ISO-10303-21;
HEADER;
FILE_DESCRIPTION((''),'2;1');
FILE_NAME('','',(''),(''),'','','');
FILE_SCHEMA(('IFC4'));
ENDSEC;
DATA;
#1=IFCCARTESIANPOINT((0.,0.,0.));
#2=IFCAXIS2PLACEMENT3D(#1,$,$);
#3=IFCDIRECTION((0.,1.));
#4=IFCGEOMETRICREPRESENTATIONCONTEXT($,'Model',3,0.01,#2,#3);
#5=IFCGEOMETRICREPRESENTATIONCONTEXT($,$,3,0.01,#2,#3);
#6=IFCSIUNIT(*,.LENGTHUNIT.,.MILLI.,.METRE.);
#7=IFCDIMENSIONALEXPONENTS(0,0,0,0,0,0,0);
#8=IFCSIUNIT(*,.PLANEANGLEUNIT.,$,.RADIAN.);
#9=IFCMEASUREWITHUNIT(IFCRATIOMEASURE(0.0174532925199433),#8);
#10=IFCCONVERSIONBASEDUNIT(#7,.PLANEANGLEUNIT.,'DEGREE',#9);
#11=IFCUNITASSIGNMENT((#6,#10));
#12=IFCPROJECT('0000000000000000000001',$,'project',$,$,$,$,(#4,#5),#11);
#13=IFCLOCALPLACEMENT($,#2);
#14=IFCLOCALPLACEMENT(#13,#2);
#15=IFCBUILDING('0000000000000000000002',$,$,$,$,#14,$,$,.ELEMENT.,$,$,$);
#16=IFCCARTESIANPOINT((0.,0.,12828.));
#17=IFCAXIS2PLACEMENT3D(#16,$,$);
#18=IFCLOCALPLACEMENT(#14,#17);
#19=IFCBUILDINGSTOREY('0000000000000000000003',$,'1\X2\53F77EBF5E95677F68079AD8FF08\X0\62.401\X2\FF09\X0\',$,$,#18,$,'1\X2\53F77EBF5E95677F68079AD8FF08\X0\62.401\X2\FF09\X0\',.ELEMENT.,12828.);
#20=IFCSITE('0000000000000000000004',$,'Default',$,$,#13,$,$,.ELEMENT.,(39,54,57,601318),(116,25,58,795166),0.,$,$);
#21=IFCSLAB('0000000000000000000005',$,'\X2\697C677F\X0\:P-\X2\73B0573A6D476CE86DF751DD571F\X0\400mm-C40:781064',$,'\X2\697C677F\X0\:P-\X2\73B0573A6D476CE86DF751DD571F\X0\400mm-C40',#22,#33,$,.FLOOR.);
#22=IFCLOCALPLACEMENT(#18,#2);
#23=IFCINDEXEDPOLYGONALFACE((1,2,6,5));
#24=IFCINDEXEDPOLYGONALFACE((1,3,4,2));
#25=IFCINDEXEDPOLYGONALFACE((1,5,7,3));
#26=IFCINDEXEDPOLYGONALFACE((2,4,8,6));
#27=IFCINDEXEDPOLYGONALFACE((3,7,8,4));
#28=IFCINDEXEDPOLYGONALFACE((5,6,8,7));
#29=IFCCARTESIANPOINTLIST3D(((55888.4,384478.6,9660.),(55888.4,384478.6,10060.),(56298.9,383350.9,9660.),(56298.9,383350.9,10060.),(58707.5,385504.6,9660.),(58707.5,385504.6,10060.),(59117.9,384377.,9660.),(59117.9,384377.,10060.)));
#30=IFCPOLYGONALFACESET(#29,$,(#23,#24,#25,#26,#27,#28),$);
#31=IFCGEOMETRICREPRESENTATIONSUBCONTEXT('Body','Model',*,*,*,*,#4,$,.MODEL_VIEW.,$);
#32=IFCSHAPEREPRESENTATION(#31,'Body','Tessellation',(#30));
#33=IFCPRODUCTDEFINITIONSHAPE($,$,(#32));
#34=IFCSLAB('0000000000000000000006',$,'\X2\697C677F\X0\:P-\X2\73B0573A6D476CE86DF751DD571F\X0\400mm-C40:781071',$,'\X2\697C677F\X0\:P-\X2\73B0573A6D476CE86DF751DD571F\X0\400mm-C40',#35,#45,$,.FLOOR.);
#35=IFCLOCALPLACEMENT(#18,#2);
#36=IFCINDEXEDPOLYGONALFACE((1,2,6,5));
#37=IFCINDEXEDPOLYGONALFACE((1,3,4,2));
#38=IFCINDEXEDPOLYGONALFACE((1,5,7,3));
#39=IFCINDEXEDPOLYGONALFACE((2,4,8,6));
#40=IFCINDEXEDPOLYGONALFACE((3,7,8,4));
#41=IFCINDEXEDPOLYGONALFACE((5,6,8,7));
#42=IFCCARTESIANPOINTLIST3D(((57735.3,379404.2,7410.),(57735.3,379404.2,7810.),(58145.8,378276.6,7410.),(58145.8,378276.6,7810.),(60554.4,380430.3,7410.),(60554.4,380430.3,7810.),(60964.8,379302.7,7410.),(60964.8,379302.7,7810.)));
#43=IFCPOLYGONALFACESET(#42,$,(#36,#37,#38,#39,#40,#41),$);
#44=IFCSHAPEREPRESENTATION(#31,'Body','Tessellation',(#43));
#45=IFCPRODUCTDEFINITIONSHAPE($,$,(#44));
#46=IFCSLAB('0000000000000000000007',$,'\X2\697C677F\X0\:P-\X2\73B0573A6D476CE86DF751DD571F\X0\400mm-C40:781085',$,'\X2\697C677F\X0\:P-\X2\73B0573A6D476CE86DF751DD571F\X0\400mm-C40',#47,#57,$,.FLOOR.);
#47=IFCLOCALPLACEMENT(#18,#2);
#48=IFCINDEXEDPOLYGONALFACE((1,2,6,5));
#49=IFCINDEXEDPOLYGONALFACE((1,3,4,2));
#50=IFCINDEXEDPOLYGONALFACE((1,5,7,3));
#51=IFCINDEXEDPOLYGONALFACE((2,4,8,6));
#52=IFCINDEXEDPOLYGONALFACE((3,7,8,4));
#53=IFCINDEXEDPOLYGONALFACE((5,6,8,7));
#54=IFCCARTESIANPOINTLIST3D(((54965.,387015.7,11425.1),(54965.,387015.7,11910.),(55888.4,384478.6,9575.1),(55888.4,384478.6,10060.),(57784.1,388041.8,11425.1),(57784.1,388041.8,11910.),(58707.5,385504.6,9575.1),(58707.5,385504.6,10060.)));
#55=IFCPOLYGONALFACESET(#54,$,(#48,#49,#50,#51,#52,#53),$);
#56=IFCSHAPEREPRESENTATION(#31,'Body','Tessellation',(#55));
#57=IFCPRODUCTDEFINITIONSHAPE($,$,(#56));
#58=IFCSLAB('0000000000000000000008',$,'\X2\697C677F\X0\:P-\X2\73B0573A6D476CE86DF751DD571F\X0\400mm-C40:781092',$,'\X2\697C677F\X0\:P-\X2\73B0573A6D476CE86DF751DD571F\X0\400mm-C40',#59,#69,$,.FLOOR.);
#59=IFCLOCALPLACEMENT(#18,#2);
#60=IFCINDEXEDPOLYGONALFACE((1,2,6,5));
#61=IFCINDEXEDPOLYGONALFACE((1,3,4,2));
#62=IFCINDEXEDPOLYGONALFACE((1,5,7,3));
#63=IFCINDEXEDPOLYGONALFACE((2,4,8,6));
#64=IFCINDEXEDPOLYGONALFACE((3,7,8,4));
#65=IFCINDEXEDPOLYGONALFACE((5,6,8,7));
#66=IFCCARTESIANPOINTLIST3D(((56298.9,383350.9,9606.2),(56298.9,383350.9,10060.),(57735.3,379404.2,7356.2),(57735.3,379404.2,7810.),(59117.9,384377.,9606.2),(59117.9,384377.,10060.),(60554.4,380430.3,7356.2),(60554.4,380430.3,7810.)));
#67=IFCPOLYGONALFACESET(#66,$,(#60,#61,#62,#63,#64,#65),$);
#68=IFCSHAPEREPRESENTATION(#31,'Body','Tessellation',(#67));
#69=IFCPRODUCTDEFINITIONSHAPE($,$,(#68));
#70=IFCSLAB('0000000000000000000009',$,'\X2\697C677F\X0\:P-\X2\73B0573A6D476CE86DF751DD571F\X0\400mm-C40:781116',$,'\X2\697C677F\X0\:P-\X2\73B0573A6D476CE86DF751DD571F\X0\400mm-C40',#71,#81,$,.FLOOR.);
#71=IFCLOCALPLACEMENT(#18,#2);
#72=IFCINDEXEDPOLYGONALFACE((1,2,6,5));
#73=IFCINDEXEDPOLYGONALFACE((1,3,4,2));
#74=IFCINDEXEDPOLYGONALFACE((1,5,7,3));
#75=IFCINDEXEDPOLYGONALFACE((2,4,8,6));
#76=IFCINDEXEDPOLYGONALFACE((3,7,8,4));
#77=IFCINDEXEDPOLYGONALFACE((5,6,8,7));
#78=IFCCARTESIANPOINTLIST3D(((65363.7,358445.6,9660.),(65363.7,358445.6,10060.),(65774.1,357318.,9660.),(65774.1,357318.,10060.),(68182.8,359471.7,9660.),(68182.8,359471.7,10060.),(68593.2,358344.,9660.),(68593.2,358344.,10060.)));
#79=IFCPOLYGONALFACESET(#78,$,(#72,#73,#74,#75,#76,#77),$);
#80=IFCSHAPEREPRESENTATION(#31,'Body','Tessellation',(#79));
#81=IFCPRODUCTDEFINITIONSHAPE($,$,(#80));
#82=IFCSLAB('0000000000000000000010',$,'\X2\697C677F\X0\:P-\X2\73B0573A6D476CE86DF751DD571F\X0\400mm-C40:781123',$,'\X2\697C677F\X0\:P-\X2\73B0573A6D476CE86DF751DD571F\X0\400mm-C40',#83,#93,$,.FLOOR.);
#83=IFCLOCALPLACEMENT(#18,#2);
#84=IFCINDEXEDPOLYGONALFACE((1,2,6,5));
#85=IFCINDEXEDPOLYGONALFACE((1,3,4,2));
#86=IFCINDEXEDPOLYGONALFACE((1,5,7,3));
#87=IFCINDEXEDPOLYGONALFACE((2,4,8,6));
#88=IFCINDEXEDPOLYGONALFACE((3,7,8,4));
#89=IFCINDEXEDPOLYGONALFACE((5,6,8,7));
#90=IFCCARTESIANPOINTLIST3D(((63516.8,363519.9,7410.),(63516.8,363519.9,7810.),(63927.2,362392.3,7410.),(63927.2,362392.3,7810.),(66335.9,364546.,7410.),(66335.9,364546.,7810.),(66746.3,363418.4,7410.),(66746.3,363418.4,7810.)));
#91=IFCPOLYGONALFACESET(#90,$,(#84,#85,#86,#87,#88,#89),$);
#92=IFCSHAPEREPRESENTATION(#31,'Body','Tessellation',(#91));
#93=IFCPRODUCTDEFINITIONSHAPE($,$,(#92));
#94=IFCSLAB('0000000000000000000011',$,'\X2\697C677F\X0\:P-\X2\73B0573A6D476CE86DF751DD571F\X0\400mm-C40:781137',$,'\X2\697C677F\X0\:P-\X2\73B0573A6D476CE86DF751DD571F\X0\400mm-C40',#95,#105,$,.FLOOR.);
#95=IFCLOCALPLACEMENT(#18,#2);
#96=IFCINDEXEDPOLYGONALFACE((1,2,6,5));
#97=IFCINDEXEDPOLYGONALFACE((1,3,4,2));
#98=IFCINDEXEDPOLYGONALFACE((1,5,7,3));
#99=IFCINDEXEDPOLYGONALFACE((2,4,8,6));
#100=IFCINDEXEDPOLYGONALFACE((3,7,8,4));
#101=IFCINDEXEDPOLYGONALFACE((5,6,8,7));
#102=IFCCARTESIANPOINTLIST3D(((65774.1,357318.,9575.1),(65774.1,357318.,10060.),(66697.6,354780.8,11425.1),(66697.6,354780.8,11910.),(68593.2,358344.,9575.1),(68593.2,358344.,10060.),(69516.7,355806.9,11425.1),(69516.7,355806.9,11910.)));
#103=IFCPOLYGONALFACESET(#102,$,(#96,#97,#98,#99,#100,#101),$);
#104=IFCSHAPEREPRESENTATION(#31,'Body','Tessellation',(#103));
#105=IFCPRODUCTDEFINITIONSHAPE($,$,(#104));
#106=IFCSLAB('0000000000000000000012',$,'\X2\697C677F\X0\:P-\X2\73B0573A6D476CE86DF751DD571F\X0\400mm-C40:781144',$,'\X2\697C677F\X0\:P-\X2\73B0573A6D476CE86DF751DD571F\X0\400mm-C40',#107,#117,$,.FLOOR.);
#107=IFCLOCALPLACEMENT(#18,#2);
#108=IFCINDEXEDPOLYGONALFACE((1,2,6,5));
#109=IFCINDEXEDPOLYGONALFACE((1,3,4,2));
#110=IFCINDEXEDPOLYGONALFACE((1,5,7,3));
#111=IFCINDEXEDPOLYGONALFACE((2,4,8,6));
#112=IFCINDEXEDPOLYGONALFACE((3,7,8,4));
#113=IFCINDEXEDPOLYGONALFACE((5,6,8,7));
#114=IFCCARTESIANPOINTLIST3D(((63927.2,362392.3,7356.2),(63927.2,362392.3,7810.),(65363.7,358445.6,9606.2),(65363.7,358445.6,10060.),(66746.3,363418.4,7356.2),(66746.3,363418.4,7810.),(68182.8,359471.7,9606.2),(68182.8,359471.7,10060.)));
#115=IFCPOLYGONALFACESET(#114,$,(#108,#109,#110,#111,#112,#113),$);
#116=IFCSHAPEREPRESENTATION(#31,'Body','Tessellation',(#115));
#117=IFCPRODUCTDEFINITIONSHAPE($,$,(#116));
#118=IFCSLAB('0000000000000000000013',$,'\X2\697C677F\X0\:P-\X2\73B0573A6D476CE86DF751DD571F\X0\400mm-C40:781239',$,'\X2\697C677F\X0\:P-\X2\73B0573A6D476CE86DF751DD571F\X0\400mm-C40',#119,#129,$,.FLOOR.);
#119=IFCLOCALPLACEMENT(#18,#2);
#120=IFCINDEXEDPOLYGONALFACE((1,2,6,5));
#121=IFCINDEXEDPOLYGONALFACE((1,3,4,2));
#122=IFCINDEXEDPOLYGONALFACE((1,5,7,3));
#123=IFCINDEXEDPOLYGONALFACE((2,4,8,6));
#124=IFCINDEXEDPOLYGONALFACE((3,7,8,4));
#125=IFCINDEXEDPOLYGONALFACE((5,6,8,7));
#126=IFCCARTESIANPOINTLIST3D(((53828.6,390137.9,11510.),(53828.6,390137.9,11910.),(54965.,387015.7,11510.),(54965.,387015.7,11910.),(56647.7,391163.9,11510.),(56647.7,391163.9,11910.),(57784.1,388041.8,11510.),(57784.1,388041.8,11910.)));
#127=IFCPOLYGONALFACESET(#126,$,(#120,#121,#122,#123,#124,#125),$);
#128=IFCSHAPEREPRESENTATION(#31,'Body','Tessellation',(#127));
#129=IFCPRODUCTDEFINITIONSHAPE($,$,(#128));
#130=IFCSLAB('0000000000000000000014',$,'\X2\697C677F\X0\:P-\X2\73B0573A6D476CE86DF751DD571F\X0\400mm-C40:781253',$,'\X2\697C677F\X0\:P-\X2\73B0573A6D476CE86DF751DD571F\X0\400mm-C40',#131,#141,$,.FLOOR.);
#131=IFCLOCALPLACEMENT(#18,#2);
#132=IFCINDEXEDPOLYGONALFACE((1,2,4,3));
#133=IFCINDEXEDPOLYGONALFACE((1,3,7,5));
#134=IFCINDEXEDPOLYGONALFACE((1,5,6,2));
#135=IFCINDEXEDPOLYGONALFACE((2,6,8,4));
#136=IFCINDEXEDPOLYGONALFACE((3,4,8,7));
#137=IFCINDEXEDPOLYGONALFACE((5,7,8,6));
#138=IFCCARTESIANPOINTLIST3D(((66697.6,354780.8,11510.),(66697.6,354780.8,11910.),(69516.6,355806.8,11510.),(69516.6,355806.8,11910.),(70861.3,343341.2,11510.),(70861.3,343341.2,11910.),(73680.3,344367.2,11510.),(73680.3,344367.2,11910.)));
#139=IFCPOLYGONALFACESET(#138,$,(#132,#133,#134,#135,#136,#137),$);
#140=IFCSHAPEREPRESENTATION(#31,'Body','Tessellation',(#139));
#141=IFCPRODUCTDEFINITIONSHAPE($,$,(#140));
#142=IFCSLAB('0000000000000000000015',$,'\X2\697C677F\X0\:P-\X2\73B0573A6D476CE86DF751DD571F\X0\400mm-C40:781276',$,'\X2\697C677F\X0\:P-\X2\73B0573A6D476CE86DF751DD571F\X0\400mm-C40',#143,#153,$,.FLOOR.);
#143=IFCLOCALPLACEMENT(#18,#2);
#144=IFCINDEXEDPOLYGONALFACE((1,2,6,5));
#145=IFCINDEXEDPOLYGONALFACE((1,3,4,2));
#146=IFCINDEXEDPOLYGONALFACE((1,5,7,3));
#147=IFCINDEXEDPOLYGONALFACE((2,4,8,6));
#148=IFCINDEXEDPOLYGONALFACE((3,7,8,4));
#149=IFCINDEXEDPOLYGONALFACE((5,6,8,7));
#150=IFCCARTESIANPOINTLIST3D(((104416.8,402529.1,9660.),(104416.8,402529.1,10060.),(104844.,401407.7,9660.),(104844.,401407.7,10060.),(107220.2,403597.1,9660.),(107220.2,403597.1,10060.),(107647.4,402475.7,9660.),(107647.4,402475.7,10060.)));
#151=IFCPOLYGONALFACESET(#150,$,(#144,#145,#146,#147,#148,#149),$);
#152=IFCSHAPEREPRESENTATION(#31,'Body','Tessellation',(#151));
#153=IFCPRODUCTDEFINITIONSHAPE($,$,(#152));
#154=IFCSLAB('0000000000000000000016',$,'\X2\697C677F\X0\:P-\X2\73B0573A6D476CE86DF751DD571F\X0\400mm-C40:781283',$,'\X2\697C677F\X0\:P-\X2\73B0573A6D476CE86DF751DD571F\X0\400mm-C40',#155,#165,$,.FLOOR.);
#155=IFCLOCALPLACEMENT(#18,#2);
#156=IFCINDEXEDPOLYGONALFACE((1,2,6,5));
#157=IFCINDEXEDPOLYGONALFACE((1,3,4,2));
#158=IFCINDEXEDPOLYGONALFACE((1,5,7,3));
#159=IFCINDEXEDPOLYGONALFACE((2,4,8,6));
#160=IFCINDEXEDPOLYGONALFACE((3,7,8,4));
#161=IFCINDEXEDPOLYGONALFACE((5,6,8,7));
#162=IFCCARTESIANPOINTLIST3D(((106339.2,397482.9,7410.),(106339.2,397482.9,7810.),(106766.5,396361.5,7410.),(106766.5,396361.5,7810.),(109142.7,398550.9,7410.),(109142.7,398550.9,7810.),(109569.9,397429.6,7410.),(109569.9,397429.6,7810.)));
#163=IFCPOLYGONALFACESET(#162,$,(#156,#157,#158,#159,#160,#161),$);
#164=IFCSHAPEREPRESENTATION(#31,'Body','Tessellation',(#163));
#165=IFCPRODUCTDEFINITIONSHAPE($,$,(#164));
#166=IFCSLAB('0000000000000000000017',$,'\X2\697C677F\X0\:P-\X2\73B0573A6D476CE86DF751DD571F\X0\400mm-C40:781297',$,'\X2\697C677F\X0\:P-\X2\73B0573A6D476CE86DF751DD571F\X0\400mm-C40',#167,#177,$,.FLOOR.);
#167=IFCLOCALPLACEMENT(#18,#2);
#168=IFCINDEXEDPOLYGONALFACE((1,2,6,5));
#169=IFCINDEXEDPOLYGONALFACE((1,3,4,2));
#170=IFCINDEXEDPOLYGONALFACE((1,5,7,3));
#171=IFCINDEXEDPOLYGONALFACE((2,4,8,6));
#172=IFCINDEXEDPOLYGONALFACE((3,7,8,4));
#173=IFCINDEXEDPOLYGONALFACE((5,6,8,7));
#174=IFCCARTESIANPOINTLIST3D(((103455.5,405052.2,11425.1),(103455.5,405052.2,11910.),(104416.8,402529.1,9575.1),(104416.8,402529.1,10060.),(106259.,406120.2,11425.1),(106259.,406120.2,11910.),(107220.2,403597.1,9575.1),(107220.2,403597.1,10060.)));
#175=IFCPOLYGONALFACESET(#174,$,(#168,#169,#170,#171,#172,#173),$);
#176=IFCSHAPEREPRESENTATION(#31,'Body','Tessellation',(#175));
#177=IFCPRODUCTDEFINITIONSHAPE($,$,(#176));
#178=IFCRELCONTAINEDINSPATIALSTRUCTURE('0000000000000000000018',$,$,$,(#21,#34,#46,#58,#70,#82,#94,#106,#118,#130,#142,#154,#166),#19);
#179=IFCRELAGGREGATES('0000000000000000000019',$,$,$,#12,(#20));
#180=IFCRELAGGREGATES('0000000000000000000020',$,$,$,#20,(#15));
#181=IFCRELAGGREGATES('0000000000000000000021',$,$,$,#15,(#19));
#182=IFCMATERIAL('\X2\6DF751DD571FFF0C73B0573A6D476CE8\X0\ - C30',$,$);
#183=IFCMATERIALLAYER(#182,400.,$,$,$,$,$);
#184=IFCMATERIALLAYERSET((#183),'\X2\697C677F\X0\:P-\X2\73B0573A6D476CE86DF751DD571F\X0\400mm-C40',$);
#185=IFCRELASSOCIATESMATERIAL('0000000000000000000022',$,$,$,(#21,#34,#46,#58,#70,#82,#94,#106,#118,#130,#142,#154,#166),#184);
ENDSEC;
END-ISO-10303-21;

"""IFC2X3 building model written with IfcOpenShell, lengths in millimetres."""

from ifc_helpers import new_model, entity, si_unit, converted_unit, direction, frame, frame_2d, origin, place, context, subcontext, project, spatial, polyline, rectangle, outline, extrude, clip, halfspace, material, layer, layer_set, layer_usage, element, save


model = new_model("IFC2X3")

# Units and contexts
model_context = context("Model", 3, precision=0.01, world=origin(), true_north=direction((0.0, 1.0)))
context_of_model = context(None, 3, precision=0.01, world=origin(), true_north=direction((0.0, 1.0)))
body_context = subcontext(model_context, "Body", "Model", "MODEL_VIEW")
ifc_project = project(units=[si_unit("LENGTHUNIT", "METRE", prefix="MILLI"), converted_unit("PLANEANGLEUNIT", "DEGREE", entity("IfcRatioMeasure", 0.0174532925199433), si_unit("PLANEANGLEUNIT", "RADIAN"), dimensions=[0, 0, 0, 0, 0, 0, 0])], contexts=[model_context, context_of_model])

# Site, building, storey
site_placement = place(None, origin())
site = spatial("IfcSite", under=ifc_project, at=site_placement, Name="Default", CompositionType="ELEMENT", RefLatitude=(39, 54, 57, 601318), RefLongitude=(116, 25, 58, 795166), RefElevation=0.0)
building_placement = place(site_placement, origin())
building = spatial("IfcBuilding", under=site, at=building_placement, CompositionType="ELEMENT")
storey_placement = place(building_placement, frame((0.0, 0.0, 12828.0)))
storey = spatial("IfcBuildingStorey", under=building, at=storey_placement, Name="1号线底板标高（62.401）", LongName="1号线底板标高（62.401）", CompositionType="ELEMENT", Elevation=12828.0)

# Slabs
ifc_material = material(Name="混凝土，现场浇注 - C30")
ifc_layer = layer(ifc_material, 400.0)
ifc_layer_set = layer_set([ifc_layer], Name="楼板:P-现场浇注混凝土400mm-C40")
ifc_layer_usage_1 = layer_usage(ifc_layer_set, "AXIS3", "POSITIVE", 0.0)
slab_1_placement = place(storey_placement, origin())
element("IfcSlab", 1, at=slab_1_placement, inside=storey, material=ifc_layer_usage_1, Name="楼板:P-现场浇注混凝土400mm-C40:781064", ObjectType="楼板:P-现场浇注混凝土400mm-C40", PredefinedType="FLOOR", context=body_context, shape_type="SweptSolid", body=[
    extrude(rectangle(XDim=1200.0, YDim=3000.0, at=frame_2d((0.0, 0.0), x_axis=(1.0, 0.0))), frame((57503.2, 384427.8, 10060.0), z_axis=(0.0, 0.0, -1.0), x_axis=(0.34202, -0.939693, 0.0)), (0.0, 0.0, 1.0), 400.0),
])
ifc_layer_usage_2 = layer_usage(ifc_layer_set, "AXIS3", "POSITIVE", 0.0)
slab_2_placement = place(storey_placement, origin())
element("IfcSlab", 2, at=slab_2_placement, inside=storey, material=ifc_layer_usage_2, Name="楼板:P-现场浇注混凝土400mm-C40:781071", ObjectType="楼板:P-现场浇注混凝土400mm-C40", PredefinedType="FLOOR", context=body_context, shape_type="SweptSolid", body=[
    extrude(rectangle(XDim=1200.0, YDim=3000.0, at=frame_2d((0.0, 0.0), x_axis=(1.0, 0.0))), frame((59350.1, 379353.4, 7810.0), z_axis=(0.0, 0.0, -1.0), x_axis=(0.34202, -0.939693, 0.0)), (0.0, 0.0, 1.0), 400.0),
])
ifc_layer_usage_3 = layer_usage(ifc_layer_set, "AXIS3", "POSITIVE", 0.0)
slab_3_placement = place(storey_placement, origin())
element("IfcSlab", 3, at=slab_3_placement, inside=storey, material=ifc_layer_usage_3, Name="楼板:P-现场浇注混凝土400mm-C40:781085", ObjectType="楼板:P-现场浇注混凝土400mm-C40", PredefinedType="FLOOR", context=body_context, shape_type="Clipping", body=[
    clip(clip(extrude(rectangle(XDim=3273.0, YDim=3000.0, at=frame_2d((0.0, 0.0), x_axis=(1.0, 0.0))), frame((56836.2, 386260.2, 10985.0), z_axis=(-0.193321, 0.531144, -0.824932), x_axis=(0.282143, -0.775183, -0.565231)), (0.565231, 0.0, 0.824932), 587.8), halfspace(frame((56374.5, 387528.8, 11425.1), z_axis=(-0.193321, 0.531144, -0.824932), x_axis=(0.981136, 0.104655, -0.162543)), False)), halfspace(frame((56374.5, 387528.8, 11910.0), z_axis=(0.193321, -0.531144, 0.824932), x_axis=(0.981136, 0.104655, -0.162543)), False)),
])
ifc_layer_usage_4 = layer_usage(ifc_layer_set, "AXIS3", "POSITIVE", 0.0)
slab_4_placement = place(storey_placement, origin())
element("IfcSlab", 4, at=slab_4_placement, inside=storey, material=ifc_layer_usage_4, Name="楼板:P-现场浇注混凝土400mm-C40:781092", ObjectType="楼板:P-现场浇注混凝土400mm-C40", PredefinedType="FLOOR", context=body_context, shape_type="Clipping", body=[
    clip(clip(extrude(rectangle(XDim=4764.7, YDim=3000.0, at=frame_2d((0.0, 0.0), x_axis=(1.0, 0.0))), frame((58426.6, 381890.6, 8935.0), z_axis=(-0.161509, 0.443743, -0.88148), x_axis=(0.301484, -0.82832, -0.472221)), (0.472221, 0.0, 0.88148), 514.8), halfspace(frame((57708.4, 383864.0, 9606.2), z_axis=(-0.161509, 0.443743, -0.88148), x_axis=(0.986871, 0.072622, -0.144261)), False)), halfspace(frame((57708.4, 383864.0, 10060.0), z_axis=(0.161509, -0.443743, 0.88148), x_axis=(0.986871, 0.072622, -0.144261)), False)),
])
ifc_layer_usage_5 = layer_usage(ifc_layer_set, "AXIS3", "POSITIVE", 0.0)
slab_5_placement = place(storey_placement, origin())
element("IfcSlab", 5, at=slab_5_placement, inside=storey, material=ifc_layer_usage_5, Name="楼板:P-现场浇注混凝土400mm-C40:781116", ObjectType="楼板:P-现场浇注混凝土400mm-C40", PredefinedType="FLOOR", context=body_context, shape_type="SweptSolid", body=[
    extrude(rectangle(XDim=1200.0, YDim=3000.0, at=frame_2d((0.0, 0.0), x_axis=(1.0, 0.0))), frame((66978.5, 358394.8, 10060.0), z_axis=(0.0, 0.0, -1.0), x_axis=(0.342025, -0.939691, 0.0)), (0.0, 0.0, 1.0), 400.0),
])
ifc_layer_usage_6 = layer_usage(ifc_layer_set, "AXIS3", "POSITIVE", 0.0)
slab_6_placement = place(storey_placement, origin())
element("IfcSlab", 6, at=slab_6_placement, inside=storey, material=ifc_layer_usage_6, Name="楼板:P-现场浇注混凝土400mm-C40:781123", ObjectType="楼板:P-现场浇注混凝土400mm-C40", PredefinedType="FLOOR", context=body_context, shape_type="SweptSolid", body=[
    extrude(rectangle(XDim=1200.0, YDim=3000.0, at=frame_2d((0.0, 0.0), x_axis=(1.0, 0.0))), frame((65131.5, 363469.1, 7810.0), z_axis=(0.0, 0.0, -1.0), x_axis=(0.342025, -0.939691, 0.0)), (0.0, 0.0, 1.0), 400.0),
])
ifc_layer_usage_7 = layer_usage(ifc_layer_set, "AXIS3", "POSITIVE", 0.0)
slab_7_placement = place(storey_placement, origin())
element("IfcSlab", 7, at=slab_7_placement, inside=storey, material=ifc_layer_usage_7, Name="楼板:P-现场浇注混凝土400mm-C40:781137", ObjectType="楼板:P-现场浇注混凝土400mm-C40", PredefinedType="FLOOR", context=body_context, shape_type="Clipping", body=[
    clip(clip(extrude(rectangle(XDim=3273.0, YDim=3000.0, at=frame_2d((0.0, 0.0), x_axis=(1.0, 0.0))), frame((67645.4, 356562.4, 10985.0), z_axis=(0.193323, -0.531143, -0.824932), x_axis=(0.282147, -0.775181, 0.565231)), (-0.565231, 0.0, 0.824932), 587.8), halfspace(frame((68107.1, 355293.8, 11425.1), z_axis=(0.193323, -0.531143, -0.824932), x_axis=(0.981135, 0.104657, 0.162545)), False)), halfspace(frame((68107.1, 355293.8, 11910.0), z_axis=(-0.193323, 0.531143, 0.824932), x_axis=(0.981135, 0.104657, 0.162545)), False)),
])
ifc_layer_usage_8 = layer_usage(ifc_layer_set, "AXIS3", "POSITIVE", 0.0)
slab_8_placement = place(storey_placement, origin())
element("IfcSlab", 8, at=slab_8_placement, inside=storey, material=ifc_layer_usage_8, Name="楼板:P-现场浇注混凝土400mm-C40:781144", ObjectType="楼板:P-现场浇注混凝土400mm-C40", PredefinedType="FLOOR", context=body_context, shape_type="Clipping", body=[
    clip(clip(extrude(rectangle(XDim=4764.7, YDim=3000.0, at=frame_2d((0.0, 0.0), x_axis=(1.0, 0.0))), frame((66055.0, 360932.0, 8935.0), z_axis=(0.161511, -0.443742, -0.88148), x_axis=(0.301488, -0.828319, 0.472221)), (-0.472221, 0.0, 0.88148), 514.8), halfspace(frame((66773.2, 358958.6, 9606.2), z_axis=(0.161511, -0.443742, -0.88148), x_axis=(0.986871, 0.072623, 0.144263)), False)), halfspace(frame((66773.2, 358958.6, 10060.0), z_axis=(-0.161511, 0.443742, 0.88148), x_axis=(0.986871, 0.072623, 0.144263)), False)),
])
ifc_layer_usage_9 = layer_usage(ifc_layer_set, "AXIS3", "POSITIVE", 0.0)
slab_9_placement = place(storey_placement, origin())
element("IfcSlab", 9, at=slab_9_placement, inside=storey, material=ifc_layer_usage_9, Name="楼板:P-现场浇注混凝土400mm-C40:781239", ObjectType="楼板:P-现场浇注混凝土400mm-C40", PredefinedType="FLOOR", context=body_context, shape_type="SweptSolid", body=[
    extrude(rectangle(XDim=3322.5, YDim=3000.0, at=frame_2d((0.0, 0.0), x_axis=(1.0, 0.0))), frame((55806.3, 389089.8, 11910.0), z_axis=(0.0, 0.0, -1.0), x_axis=(0.34202, -0.939693, 0.0)), (0.0, 0.0, 1.0), 400.0),
])
ifc_layer_usage_10 = layer_usage(ifc_layer_set, "AXIS3", "POSITIVE", 0.0)
slab_10_placement = place(storey_placement, origin())
element("IfcSlab", 10, at=slab_10_placement, inside=storey, material=ifc_layer_usage_10, Name="楼板:P-现场浇注混凝土400mm-C40:781253", ObjectType="楼板:P-现场浇注混凝土400mm-C40", PredefinedType="FLOOR", context=body_context, shape_type="SweptSolid", body=[
    extrude(outline(polyline([(-6086.9, -1500.0), (6086.9, -1500.0), (6086.9, 1500.0), (-6086.9, 1499.9), (-6086.9, -1500.0)])), frame((70189.0, 349574.0, 11910.0), z_axis=(0.0, 0.0, -1.0), x_axis=(0.342025, -0.939691, 0.0)), (0.0, 0.0, 1.0), 400.0),
])
ifc_layer_usage_11 = layer_usage(ifc_layer_set, "AXIS3", "POSITIVE", 0.0)
slab_11_placement = place(storey_placement, origin())
element("IfcSlab", 11, at=slab_11_placement, inside=storey, material=ifc_layer_usage_11, Name="楼板:P-现场浇注混凝土400mm-C40:781276", ObjectType="楼板:P-现场浇注混凝土400mm-C40", PredefinedType="FLOOR", context=body_context, shape_type="SweptSolid", body=[
    extrude(rectangle(XDim=3000.0, YDim=1200.0, at=frame_2d((0.0, 0.0), x_axis=(1.0, 0.0))), frame((106032.1, 402502.4, 10060.0), z_axis=(0.0, 0.0, -1.0), x_axis=(0.93448, 0.356017, 0.0)), (0.0, 0.0, 1.0), 400.0),
])
ifc_layer_usage_12 = layer_usage(ifc_layer_set, "AXIS3", "POSITIVE", 0.0)
slab_12_placement = place(storey_placement, origin())
element("IfcSlab", 12, at=slab_12_placement, inside=storey, material=ifc_layer_usage_12, Name="楼板:P-现场浇注混凝土400mm-C40:781283", ObjectType="楼板:P-现场浇注混凝土400mm-C40", PredefinedType="FLOOR", context=body_context, shape_type="SweptSolid", body=[
    extrude(rectangle(XDim=3000.0, YDim=1200.0, at=frame_2d((0.0, 0.0), x_axis=(1.0, 0.0))), frame((107954.6, 397456.2, 7810.0), z_axis=(0.0, 0.0, -1.0), x_axis=(0.93448, 0.356017, 0.0)), (0.0, 0.0, 1.0), 400.0),
])
ifc_layer_usage_13 = layer_usage(ifc_layer_set, "AXIS3", "POSITIVE", 0.0)
slab_13_placement = place(storey_placement, origin())
element("IfcSlab", 13, at=slab_13_placement, inside=storey, material=ifc_layer_usage_13, Name="楼板:P-现场浇注混凝土400mm-C40:781297", ObjectType="楼板:P-现场浇注混凝土400mm-C40", PredefinedType="FLOOR", context=body_context, shape_type="Clipping", body=[
    clip(clip(extrude(rectangle(XDim=3273.0, YDim=3000.0, at=frame_2d((0.0, 0.0), x_axis=(1.0, 0.0))), frame((105337.9, 404324.6, 10985.0), z_axis=(-0.201232, 0.528197, -0.824932), x_axis=(0.29369, -0.770882, -0.565231)), (0.565231, 0.0, 0.824932), 587.8), halfspace(frame((104857.2, 405586.2, 11910.0), z_axis=(0.201232, -0.528197, 0.824932), x_axis=(0.979544, 0.10851, -0.169469)), False)), halfspace(frame((104857.2, 405586.2, 11425.1), z_axis=(-0.201232, 0.528197, -0.824932), x_axis=(0.979544, 0.10851, -0.169469)), False)),
])

save(model, "model.ifc")
